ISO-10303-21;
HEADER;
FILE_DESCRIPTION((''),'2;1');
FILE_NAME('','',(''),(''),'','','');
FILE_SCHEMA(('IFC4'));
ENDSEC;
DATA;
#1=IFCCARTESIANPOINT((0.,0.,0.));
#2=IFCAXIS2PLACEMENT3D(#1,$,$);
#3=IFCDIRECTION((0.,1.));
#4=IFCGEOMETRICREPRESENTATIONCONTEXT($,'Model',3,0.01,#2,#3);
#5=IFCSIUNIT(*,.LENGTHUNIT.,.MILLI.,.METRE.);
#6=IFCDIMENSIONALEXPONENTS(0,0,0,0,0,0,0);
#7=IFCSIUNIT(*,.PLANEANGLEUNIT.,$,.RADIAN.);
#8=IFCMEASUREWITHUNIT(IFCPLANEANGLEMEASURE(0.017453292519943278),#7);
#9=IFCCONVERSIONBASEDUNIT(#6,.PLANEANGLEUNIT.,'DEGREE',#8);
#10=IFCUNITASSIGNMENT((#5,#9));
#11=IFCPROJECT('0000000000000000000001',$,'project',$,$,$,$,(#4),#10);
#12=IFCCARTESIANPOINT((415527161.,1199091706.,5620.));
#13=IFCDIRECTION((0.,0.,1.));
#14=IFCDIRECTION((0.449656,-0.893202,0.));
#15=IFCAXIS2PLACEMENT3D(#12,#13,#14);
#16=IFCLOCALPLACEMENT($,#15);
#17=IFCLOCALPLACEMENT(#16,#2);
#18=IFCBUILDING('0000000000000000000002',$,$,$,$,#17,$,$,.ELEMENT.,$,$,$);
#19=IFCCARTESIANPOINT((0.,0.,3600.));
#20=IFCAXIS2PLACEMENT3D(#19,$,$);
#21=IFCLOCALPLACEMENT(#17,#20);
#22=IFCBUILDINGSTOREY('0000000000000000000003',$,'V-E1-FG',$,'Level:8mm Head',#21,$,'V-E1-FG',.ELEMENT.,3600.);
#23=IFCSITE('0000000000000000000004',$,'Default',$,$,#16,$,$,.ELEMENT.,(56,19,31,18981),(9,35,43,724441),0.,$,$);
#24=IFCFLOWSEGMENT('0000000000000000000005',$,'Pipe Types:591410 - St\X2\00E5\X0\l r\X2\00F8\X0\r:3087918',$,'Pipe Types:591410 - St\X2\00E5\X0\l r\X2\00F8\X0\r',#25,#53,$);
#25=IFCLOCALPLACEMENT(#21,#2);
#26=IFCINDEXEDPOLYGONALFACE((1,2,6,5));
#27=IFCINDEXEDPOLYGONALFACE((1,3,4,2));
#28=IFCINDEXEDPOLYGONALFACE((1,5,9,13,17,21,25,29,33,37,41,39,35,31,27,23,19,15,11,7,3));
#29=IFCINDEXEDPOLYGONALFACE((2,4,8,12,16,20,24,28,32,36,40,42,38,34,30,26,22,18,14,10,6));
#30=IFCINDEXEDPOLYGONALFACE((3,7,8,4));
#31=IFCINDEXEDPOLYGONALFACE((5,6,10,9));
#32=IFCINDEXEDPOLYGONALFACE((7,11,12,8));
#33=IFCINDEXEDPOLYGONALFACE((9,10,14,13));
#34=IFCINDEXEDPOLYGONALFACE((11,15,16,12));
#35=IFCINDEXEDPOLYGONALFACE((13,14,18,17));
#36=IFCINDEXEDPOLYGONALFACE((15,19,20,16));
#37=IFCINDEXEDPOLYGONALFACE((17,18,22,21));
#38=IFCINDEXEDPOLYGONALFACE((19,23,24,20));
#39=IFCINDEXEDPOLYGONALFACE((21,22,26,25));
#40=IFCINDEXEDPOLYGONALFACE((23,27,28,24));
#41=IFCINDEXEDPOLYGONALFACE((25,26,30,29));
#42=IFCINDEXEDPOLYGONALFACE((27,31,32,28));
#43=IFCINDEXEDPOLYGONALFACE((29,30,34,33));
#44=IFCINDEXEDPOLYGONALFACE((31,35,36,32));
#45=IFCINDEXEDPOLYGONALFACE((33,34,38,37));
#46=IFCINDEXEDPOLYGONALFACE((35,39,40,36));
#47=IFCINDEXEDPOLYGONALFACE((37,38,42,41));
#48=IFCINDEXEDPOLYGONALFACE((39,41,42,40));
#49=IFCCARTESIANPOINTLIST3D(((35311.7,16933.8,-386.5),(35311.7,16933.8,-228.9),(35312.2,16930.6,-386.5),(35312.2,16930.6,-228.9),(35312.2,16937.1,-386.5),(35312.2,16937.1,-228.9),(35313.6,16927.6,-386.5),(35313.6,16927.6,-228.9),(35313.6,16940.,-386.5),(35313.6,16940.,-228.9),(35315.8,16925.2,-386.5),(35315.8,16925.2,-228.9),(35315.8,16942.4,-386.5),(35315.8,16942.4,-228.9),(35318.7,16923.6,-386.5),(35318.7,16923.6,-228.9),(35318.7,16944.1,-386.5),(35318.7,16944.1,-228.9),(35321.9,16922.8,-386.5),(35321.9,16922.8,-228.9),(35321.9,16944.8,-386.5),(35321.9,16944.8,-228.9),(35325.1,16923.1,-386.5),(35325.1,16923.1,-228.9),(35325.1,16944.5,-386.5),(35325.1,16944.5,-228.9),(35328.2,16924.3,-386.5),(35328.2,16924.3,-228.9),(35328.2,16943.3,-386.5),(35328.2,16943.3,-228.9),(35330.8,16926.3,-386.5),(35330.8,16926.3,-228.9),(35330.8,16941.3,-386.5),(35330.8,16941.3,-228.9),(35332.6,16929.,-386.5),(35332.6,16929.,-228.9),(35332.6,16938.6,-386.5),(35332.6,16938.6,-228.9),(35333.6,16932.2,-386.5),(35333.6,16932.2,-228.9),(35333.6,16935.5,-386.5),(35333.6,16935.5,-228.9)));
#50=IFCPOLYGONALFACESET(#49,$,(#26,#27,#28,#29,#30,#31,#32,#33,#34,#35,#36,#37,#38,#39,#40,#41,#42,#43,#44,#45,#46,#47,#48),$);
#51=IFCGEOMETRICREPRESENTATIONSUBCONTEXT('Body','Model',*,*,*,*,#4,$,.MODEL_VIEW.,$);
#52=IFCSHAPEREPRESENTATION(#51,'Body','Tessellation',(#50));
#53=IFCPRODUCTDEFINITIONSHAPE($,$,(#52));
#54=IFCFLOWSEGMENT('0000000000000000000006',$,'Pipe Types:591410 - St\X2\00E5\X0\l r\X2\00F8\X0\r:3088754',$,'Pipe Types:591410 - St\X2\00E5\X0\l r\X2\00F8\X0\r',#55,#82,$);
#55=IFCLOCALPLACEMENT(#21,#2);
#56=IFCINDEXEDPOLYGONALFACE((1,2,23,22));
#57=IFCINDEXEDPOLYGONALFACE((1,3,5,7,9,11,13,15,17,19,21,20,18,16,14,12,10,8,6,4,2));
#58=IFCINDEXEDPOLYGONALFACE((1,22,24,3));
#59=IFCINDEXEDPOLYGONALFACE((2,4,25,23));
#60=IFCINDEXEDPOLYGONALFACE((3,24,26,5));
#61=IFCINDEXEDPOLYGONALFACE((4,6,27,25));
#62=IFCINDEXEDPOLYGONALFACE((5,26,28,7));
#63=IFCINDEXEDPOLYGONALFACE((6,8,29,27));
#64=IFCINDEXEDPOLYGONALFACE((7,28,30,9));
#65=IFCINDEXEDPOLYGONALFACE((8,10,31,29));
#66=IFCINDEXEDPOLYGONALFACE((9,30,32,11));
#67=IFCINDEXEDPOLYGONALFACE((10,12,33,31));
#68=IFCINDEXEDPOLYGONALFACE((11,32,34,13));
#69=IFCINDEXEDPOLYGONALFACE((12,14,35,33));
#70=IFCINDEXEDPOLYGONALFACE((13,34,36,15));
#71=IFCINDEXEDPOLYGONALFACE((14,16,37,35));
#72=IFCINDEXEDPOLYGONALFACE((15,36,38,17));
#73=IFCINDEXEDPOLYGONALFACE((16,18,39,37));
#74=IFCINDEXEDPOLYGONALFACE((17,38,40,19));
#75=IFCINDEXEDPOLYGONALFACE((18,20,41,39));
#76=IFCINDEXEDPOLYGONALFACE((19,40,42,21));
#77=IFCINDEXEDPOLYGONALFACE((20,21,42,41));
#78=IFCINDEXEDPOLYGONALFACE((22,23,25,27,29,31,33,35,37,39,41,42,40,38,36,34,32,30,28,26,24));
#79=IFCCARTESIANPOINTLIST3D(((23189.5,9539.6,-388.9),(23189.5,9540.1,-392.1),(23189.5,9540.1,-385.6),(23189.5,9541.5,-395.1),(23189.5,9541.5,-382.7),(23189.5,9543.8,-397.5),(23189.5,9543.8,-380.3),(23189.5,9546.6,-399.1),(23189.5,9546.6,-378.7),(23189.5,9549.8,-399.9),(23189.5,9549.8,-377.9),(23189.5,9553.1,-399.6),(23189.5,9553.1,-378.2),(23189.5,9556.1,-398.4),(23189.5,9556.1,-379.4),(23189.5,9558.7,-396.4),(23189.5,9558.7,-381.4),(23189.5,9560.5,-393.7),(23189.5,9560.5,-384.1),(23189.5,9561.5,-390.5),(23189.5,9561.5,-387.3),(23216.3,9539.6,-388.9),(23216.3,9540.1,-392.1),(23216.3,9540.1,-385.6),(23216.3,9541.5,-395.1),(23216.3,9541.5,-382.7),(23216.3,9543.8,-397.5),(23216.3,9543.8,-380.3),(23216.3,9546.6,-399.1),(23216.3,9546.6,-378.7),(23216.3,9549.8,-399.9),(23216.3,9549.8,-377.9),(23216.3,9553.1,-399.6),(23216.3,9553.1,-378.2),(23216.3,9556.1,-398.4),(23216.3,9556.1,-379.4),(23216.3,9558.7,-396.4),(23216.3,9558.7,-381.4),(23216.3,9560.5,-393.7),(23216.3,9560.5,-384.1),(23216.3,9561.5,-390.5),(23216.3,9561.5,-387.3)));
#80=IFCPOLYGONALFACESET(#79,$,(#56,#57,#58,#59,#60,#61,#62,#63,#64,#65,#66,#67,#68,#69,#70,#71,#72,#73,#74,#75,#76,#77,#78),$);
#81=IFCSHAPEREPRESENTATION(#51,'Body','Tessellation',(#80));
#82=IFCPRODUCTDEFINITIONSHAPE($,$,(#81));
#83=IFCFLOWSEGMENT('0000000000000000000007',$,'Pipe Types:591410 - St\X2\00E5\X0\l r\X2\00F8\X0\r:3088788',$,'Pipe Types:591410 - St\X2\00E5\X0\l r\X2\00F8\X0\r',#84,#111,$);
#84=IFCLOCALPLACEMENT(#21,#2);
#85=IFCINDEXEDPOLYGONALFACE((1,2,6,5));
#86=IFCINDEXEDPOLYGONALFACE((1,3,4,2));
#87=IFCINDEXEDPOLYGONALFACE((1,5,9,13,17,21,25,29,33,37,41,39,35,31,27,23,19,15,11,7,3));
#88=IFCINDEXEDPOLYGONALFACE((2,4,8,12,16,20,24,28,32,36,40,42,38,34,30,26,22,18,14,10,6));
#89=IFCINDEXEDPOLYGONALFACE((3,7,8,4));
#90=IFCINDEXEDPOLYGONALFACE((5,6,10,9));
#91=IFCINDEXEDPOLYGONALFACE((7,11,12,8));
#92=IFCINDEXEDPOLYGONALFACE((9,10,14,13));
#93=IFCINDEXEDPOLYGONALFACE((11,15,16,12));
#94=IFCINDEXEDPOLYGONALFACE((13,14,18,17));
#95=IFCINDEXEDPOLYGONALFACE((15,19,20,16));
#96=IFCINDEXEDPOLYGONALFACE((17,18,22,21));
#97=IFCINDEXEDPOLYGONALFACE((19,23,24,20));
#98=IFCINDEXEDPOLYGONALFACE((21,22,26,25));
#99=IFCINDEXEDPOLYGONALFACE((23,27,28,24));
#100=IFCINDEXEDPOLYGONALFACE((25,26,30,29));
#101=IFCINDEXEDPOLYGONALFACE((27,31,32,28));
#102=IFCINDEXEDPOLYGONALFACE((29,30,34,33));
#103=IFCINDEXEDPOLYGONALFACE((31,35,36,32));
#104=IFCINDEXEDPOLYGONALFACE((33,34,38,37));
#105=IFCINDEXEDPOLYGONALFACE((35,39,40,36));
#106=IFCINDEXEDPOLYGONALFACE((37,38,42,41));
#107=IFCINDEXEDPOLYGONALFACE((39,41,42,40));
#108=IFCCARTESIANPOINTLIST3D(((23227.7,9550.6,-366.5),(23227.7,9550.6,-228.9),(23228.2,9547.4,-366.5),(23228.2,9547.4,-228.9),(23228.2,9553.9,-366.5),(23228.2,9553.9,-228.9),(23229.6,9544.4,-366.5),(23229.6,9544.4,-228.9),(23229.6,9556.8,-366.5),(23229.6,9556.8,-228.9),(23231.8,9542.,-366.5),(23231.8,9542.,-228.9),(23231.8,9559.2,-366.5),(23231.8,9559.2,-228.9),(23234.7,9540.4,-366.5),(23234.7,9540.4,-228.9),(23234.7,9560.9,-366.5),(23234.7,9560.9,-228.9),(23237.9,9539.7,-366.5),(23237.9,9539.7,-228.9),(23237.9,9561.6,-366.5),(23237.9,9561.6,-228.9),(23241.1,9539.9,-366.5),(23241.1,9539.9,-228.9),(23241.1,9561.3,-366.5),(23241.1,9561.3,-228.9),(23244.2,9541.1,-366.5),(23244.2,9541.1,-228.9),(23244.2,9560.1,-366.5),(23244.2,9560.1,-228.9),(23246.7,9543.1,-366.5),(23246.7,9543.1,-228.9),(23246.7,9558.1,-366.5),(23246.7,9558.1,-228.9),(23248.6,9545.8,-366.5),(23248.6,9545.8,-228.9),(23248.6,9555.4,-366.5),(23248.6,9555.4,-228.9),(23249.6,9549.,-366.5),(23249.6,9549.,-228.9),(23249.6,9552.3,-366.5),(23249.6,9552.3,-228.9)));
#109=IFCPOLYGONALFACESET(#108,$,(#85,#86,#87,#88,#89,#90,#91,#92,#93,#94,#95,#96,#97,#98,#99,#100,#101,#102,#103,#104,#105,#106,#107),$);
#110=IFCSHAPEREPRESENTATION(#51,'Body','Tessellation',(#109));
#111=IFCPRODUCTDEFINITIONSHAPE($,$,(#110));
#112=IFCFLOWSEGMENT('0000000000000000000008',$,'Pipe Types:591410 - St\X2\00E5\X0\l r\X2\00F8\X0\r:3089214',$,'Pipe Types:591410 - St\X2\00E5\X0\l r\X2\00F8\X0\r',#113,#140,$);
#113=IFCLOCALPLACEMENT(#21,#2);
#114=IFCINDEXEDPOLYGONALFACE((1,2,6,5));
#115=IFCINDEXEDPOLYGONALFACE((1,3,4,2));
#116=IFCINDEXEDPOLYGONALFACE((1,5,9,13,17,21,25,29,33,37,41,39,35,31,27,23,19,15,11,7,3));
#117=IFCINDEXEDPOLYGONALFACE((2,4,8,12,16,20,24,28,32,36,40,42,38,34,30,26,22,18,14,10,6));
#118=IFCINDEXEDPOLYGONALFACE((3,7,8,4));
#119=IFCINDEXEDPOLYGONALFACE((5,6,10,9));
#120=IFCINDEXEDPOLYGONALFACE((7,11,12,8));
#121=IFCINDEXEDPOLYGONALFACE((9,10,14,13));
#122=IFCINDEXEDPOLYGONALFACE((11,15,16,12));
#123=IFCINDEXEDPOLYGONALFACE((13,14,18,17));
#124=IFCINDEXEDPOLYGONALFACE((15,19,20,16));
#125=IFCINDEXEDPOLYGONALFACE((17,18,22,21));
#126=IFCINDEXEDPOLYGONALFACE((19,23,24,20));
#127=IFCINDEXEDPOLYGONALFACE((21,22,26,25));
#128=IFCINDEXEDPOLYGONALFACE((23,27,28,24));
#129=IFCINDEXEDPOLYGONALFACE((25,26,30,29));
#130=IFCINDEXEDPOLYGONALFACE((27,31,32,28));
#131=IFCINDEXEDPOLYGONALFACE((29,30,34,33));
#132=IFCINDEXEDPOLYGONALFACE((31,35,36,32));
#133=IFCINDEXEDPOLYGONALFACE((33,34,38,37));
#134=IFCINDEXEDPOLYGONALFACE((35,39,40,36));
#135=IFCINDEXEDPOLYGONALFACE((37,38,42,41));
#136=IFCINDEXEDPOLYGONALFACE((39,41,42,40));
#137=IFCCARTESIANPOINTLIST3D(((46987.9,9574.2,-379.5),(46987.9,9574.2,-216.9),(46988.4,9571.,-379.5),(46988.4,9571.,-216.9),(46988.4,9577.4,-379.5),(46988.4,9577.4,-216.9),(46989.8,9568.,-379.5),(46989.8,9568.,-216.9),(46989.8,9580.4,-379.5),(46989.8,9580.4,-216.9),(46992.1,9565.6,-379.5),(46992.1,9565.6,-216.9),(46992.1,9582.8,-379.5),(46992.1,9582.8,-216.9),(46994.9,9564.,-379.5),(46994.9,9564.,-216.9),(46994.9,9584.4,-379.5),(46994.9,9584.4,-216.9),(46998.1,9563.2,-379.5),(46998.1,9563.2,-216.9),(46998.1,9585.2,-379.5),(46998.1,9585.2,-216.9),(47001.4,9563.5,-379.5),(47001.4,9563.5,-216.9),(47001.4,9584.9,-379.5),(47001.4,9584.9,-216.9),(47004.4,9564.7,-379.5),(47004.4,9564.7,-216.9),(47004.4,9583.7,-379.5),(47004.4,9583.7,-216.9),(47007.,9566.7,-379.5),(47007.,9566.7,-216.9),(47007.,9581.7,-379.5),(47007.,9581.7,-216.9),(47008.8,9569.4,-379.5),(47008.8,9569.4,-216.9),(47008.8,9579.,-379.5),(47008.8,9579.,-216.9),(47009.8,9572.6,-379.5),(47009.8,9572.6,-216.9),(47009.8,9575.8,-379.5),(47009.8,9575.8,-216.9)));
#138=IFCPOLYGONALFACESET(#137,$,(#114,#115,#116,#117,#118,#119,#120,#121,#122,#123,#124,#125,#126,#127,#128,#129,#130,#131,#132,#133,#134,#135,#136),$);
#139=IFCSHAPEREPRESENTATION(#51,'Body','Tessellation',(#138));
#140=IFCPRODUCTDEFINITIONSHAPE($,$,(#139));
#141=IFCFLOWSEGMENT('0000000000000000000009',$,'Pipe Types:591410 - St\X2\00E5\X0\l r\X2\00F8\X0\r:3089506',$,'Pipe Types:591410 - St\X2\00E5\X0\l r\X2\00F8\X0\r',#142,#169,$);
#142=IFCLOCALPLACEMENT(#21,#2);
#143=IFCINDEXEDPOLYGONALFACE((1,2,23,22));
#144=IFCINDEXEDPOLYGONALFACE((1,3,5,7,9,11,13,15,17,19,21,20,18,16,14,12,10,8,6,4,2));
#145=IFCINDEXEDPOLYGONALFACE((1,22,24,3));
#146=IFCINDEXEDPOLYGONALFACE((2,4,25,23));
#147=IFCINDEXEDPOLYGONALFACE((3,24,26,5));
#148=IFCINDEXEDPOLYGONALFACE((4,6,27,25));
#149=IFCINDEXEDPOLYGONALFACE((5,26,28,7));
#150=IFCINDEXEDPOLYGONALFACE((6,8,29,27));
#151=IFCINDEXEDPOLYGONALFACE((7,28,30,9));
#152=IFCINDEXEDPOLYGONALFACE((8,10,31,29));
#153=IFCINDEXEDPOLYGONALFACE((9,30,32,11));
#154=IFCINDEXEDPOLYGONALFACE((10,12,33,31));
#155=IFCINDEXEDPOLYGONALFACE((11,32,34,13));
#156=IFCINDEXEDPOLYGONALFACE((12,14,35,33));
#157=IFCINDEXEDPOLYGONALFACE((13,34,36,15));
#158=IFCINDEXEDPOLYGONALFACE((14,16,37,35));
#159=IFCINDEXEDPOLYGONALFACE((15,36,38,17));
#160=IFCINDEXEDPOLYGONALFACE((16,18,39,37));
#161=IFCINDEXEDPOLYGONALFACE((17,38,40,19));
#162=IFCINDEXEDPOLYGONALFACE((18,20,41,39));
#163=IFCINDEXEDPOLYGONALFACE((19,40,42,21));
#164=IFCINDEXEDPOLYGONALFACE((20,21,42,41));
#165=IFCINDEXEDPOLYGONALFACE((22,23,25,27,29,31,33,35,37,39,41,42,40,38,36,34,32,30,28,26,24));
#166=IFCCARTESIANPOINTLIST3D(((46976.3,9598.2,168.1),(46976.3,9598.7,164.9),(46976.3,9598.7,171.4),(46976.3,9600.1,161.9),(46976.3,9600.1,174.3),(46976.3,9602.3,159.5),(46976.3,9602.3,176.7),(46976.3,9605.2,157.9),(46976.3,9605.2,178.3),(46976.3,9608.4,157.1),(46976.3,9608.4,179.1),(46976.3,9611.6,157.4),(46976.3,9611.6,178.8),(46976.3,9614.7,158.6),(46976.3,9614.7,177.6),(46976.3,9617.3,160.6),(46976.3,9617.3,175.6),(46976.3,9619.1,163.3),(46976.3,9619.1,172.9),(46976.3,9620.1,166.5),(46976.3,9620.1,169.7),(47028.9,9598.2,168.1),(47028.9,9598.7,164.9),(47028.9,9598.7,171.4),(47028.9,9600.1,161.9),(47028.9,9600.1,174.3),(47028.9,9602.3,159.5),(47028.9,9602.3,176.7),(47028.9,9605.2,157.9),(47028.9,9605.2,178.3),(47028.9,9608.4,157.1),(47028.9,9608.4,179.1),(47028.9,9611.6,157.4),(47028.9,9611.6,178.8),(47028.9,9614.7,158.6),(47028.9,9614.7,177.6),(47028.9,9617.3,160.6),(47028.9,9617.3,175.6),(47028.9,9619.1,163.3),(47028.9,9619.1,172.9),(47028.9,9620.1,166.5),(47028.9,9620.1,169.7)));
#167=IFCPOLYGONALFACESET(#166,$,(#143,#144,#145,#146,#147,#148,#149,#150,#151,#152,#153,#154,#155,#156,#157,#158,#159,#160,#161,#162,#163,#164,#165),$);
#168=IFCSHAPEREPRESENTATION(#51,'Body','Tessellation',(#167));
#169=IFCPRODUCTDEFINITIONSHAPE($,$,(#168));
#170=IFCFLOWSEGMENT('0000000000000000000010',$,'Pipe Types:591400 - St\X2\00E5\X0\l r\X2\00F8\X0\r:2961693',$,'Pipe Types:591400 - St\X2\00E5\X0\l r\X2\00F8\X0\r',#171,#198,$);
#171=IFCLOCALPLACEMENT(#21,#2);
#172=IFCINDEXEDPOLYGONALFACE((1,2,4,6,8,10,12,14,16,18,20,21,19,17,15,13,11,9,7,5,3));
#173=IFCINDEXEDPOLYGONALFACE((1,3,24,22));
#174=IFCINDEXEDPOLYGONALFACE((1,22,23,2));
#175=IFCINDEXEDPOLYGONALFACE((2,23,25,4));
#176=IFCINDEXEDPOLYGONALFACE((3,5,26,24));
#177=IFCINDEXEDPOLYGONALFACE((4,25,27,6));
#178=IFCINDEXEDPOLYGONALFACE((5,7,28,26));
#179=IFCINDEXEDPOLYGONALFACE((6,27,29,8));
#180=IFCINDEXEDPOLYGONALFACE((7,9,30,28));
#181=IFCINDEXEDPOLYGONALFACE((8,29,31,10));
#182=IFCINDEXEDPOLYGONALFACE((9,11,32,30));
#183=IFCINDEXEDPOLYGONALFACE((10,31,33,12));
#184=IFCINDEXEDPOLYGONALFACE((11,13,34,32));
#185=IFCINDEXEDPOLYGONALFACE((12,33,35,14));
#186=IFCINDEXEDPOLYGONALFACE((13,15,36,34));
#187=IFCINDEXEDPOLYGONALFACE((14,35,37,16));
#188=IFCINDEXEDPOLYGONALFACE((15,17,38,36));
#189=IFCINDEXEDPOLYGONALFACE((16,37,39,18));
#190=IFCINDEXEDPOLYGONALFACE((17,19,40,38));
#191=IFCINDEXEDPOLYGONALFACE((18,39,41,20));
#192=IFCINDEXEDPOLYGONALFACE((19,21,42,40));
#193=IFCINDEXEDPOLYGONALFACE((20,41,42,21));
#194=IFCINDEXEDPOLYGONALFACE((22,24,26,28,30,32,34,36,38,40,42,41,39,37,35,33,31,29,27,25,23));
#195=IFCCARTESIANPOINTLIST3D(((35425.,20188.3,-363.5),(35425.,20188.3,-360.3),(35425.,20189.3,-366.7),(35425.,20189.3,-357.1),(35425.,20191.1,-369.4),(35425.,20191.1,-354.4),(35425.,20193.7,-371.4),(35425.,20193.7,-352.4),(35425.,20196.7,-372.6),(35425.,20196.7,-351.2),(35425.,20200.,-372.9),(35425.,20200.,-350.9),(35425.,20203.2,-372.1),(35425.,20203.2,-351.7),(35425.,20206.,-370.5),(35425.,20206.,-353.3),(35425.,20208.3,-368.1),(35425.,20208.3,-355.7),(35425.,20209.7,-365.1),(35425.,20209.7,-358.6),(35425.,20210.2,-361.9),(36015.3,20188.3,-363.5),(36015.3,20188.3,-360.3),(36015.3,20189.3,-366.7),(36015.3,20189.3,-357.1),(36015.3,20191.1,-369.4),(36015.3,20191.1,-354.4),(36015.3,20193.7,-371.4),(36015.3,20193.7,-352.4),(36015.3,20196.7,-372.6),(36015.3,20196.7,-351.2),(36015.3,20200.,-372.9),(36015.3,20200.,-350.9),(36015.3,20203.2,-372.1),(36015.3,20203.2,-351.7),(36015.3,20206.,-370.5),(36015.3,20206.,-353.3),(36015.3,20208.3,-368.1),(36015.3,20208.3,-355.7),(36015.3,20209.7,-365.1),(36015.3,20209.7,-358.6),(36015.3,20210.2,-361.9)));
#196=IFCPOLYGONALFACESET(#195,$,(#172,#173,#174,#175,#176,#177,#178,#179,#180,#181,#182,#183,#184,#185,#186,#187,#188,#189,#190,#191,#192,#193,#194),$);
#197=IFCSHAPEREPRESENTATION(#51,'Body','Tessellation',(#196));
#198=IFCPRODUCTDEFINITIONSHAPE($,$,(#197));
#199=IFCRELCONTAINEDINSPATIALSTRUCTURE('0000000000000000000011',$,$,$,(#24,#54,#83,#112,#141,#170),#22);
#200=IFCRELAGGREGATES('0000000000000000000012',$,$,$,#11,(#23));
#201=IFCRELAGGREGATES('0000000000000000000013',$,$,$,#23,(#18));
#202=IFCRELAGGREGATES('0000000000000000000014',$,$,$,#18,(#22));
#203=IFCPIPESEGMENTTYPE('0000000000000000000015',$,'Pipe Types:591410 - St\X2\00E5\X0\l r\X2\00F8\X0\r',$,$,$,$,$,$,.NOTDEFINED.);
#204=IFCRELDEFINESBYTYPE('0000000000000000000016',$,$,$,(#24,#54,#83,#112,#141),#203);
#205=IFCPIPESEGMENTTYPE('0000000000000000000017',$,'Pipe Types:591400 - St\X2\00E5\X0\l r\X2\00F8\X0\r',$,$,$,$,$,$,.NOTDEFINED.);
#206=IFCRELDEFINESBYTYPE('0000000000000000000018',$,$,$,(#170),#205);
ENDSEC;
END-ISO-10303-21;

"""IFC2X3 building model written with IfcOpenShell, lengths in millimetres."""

from ifc_helpers import new_model, entity, si_unit, converted_unit, direction, frame, frame_2d, origin, origin_2d_with_axis, place, context, subcontext, project, spatial, circle, extrude, type_object, element, save


model = new_model("IFC2X3")

# Units and contexts
model_context = context("Model", 3, precision=0.01, world=origin(), true_north=direction((0.0, 1.0)))
body_context = subcontext(model_context, "Body", "Model", "MODEL_VIEW")
ifc_project = project(units=[si_unit("LENGTHUNIT", "METRE", prefix="MILLI"), converted_unit("PLANEANGLEUNIT", "DEGREE", entity("IfcPlaneAngleMeasure", 0.017453292519943278), si_unit("PLANEANGLEUNIT", "RADIAN"), dimensions=[0, 0, 0, 0, 0, 0, 0])], contexts=[model_context])

# Site, building, storey
site_placement = place(None, frame((415527161.0, 1199091706.0, 5620.0), z_axis=(0.0, 0.0, 1.0), x_axis=(0.449656, -0.893202, 0.0)))
site = spatial("IfcSite", under=ifc_project, at=site_placement, Name="Default", CompositionType="ELEMENT", RefLatitude=(56, 19, 31, 18981), RefLongitude=(9, 35, 43, 724441), RefElevation=0.0)
building_placement = place(site_placement, origin())
building = spatial("IfcBuilding", under=site, at=building_placement, CompositionType="ELEMENT")
storey_placement = place(building_placement, frame((0.0, 0.0, 3600.0)))
storey = spatial("IfcBuildingStorey", under=building, at=storey_placement, Name="V-E1-FG", ObjectType="Level:8mm Head", LongName="V-E1-FG", CompositionType="ELEMENT", Elevation=3600.0)

# Flow segments
pipe_segment_type_1 = type_object("IfcPipeSegmentType", Name="Pipe Types:591410 - Stål rør", PredefinedType="NOTDEFINED")
flow_segment_1_placement = place(storey_placement, origin())
element("IfcFlowSegment", 1, at=flow_segment_1_placement, inside=storey, type_object=pipe_segment_type_1, Name="Pipe Types:591410 - Stål rør:3087918", ObjectType="Pipe Types:591410 - Stål rør", context=body_context, shape_type="SweptSolid", body=[
    extrude(circle(Radius=11.0, at=origin_2d_with_axis()), frame((35322.7, 16933.8, -386.5), z_axis=(0.0, 0.0, 1.0), x_axis=(-1.0, 0.0, 0.0)), (0.0, 0.0, 1.0), 157.7),
])
flow_segment_2_placement = place(storey_placement, origin())
element("IfcFlowSegment", 2, at=flow_segment_2_placement, inside=storey, type_object=pipe_segment_type_1, Name="Pipe Types:591410 - Stål rør:3088754", ObjectType="Pipe Types:591410 - Stål rør", context=body_context, shape_type="SweptSolid", body=[
    extrude(circle(Radius=11.0, at=frame_2d((0.0, 0.0), x_axis=(1.0, 0.0))), frame((23189.5, 9550.6, -388.9), z_axis=(1.0, 0.0, 0.0), x_axis=(0.0, -1.0, 0.0)), (0.0, 0.0, 1.0), 26.8),
])
flow_segment_3_placement = place(storey_placement, origin())
element("IfcFlowSegment", 3, at=flow_segment_3_placement, inside=storey, type_object=pipe_segment_type_1, Name="Pipe Types:591410 - Stål rør:3088788", ObjectType="Pipe Types:591410 - Stål rør", context=body_context, shape_type="SweptSolid", body=[
    extrude(circle(Radius=11.0, at=origin_2d_with_axis()), frame((23238.7, 9550.6, -366.5), z_axis=(0.0, 0.0, 1.0), x_axis=(-1.0, 0.0, 0.0)), (0.0, 0.0, 1.0), 137.7),
])
flow_segment_4_placement = place(storey_placement, origin())
element("IfcFlowSegment", 4, at=flow_segment_4_placement, inside=storey, type_object=pipe_segment_type_1, Name="Pipe Types:591410 - Stål rør:3089214", ObjectType="Pipe Types:591410 - Stål rør", context=body_context, shape_type="SweptSolid", body=[
    extrude(circle(Radius=11.0, at=origin_2d_with_axis()), frame((46998.9, 9574.2, -379.5), z_axis=(0.0, 0.0, 1.0), x_axis=(-1.0, 0.0, 0.0)), (0.0, 0.0, 1.0), 162.7),
])
flow_segment_5_placement = place(storey_placement, origin())
element("IfcFlowSegment", 5, at=flow_segment_5_placement, inside=storey, type_object=pipe_segment_type_1, Name="Pipe Types:591410 - Stål rør:3089506", ObjectType="Pipe Types:591410 - Stål rør", context=body_context, shape_type="SweptSolid", body=[
    extrude(circle(Radius=11.0, at=frame_2d((0.0, 0.0), x_axis=(1.0, 0.0))), frame((46976.3, 9609.2, 168.1), z_axis=(1.0, 0.0, 0.0), x_axis=(0.0, -1.0, 0.0)), (0.0, 0.0, 1.0), 52.7),
])
pipe_segment_type_2 = type_object("IfcPipeSegmentType", Name="Pipe Types:591400 - Stål rør", PredefinedType="NOTDEFINED")
flow_segment_6_placement = place(storey_placement, origin())
element("IfcFlowSegment", 6, at=flow_segment_6_placement, inside=storey, type_object=pipe_segment_type_2, Name="Pipe Types:591400 - Stål rør:2961693", ObjectType="Pipe Types:591400 - Stål rør", context=body_context, shape_type="SweptSolid", body=[
    extrude(circle(Radius=11.0, at=origin_2d_with_axis()), frame((35425.0, 20199.2, -361.9), z_axis=(1.0, 0.0, 0.0), x_axis=(0.0, 1.0, 0.0)), (0.0, 0.0, 1.0), 590.3),
])

save(model, "model.ifc")
